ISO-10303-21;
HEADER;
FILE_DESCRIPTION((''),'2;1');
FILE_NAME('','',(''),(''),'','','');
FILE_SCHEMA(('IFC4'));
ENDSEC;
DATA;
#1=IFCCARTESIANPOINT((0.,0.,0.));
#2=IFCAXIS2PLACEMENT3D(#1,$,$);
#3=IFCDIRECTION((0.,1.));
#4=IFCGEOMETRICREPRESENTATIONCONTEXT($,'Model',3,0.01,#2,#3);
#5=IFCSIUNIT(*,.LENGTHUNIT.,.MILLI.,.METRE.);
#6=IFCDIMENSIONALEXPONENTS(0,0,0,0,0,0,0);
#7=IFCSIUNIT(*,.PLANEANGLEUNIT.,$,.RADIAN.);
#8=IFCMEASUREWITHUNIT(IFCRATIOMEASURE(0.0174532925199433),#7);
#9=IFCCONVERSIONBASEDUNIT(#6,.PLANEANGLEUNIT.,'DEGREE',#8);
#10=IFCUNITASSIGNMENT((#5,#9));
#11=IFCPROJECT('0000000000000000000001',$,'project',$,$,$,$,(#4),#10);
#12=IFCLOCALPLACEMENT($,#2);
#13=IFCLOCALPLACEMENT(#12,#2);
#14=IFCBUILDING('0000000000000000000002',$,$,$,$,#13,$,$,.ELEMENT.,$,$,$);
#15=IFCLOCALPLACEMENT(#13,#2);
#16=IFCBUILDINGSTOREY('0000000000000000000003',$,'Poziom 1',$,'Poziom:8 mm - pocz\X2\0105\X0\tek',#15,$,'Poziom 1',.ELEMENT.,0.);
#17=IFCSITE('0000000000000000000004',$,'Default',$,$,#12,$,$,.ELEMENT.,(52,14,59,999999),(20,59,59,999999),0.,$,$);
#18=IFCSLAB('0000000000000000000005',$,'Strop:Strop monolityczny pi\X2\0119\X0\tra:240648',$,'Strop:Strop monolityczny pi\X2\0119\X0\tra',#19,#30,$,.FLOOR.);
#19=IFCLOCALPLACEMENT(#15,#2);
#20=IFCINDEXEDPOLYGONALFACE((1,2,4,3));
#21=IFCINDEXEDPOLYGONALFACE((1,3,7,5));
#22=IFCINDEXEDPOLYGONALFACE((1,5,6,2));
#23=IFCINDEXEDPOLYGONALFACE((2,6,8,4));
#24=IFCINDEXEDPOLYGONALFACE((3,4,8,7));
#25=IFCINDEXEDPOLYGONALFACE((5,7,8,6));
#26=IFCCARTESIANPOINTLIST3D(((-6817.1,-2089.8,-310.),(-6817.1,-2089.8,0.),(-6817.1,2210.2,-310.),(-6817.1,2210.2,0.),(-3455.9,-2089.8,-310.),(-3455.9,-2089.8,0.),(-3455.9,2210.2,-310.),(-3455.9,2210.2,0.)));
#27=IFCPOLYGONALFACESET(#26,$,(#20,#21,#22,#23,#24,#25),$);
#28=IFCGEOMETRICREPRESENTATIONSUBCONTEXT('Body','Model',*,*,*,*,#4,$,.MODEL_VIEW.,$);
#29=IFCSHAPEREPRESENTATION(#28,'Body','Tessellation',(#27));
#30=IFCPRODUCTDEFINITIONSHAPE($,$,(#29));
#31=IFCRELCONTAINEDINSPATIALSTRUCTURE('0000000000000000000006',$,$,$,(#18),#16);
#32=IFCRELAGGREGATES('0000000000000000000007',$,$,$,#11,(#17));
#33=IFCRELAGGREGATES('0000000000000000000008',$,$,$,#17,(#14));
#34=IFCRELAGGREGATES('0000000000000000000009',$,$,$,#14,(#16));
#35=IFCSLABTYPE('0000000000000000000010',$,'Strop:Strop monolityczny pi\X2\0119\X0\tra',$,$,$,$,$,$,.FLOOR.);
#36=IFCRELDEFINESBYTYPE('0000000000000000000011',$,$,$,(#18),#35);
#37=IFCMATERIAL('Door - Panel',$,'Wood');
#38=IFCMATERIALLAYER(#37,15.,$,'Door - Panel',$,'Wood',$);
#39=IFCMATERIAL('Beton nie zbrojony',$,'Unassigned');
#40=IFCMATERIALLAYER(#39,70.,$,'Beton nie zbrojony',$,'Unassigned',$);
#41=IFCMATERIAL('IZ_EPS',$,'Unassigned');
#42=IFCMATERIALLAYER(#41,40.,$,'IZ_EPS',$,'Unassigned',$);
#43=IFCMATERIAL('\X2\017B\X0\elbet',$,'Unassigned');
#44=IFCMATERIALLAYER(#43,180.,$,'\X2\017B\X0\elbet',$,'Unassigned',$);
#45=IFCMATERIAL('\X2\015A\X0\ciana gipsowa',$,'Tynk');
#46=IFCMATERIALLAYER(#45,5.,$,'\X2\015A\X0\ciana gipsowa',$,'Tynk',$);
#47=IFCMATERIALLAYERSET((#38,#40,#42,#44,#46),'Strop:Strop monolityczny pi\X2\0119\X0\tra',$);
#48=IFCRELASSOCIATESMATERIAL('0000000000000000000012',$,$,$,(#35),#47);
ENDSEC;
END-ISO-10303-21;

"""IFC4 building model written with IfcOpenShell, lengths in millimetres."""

from ifc_helpers import new_model, entity, si_unit, converted_unit, direction, frame, origin, place, context, subcontext, project, spatial, indexed_curve, outline, extrude, material, layer, layer_set, type_object, element, save


model = new_model("IFC4")

# Units and contexts
model_context = context("Model", 3, precision=0.01, world=origin(), true_north=direction((0.0, 1.0)))
body_context = subcontext(model_context, "Body", "Model", "MODEL_VIEW")
ifc_project = project(units=[si_unit("LENGTHUNIT", "METRE", prefix="MILLI"), converted_unit("PLANEANGLEUNIT", "DEGREE", entity("IfcRatioMeasure", 0.0174532925199433), si_unit("PLANEANGLEUNIT", "RADIAN"), dimensions=[0, 0, 0, 0, 0, 0, 0])], contexts=[model_context])

# Site, building, storey
site_placement = place(None, origin())
site = spatial("IfcSite", under=ifc_project, at=site_placement, Name="Default", CompositionType="ELEMENT", RefLatitude=(52, 14, 59, 999999), RefLongitude=(20, 59, 59, 999999), RefElevation=0.0)
building_placement = place(site_placement, origin())
building = spatial("IfcBuilding", under=site, at=building_placement, CompositionType="ELEMENT")
storey_placement = place(building_placement, origin())
storey = spatial("IfcBuildingStorey", under=building, at=storey_placement, Name="Poziom 1", ObjectType="Poziom:8 mm - początek", LongName="Poziom 1", CompositionType="ELEMENT", Elevation=0.0)

# Slab
ifc_material_1 = material(Name="Door - Panel", Category="Wood")
ifc_layer_1 = layer(ifc_material_1, 15.0, Name="Door - Panel", Category="Wood")
ifc_material_2 = material(Name="Beton nie zbrojony", Category="Unassigned")
ifc_layer_2 = layer(ifc_material_2, 70.0, Name="Beton nie zbrojony", Category="Unassigned")
ifc_material_3 = material(Name="IZ_EPS", Category="Unassigned")
ifc_layer_3 = layer(ifc_material_3, 40.0, Name="IZ_EPS", Category="Unassigned")
ifc_material_4 = material(Name="Żelbet", Category="Unassigned")
ifc_layer_4 = layer(ifc_material_4, 180.0, Name="Żelbet", Category="Unassigned")
ifc_material_5 = material(Name="Ściana gipsowa", Category="Tynk")
ifc_layer_5 = layer(ifc_material_5, 5.0, Name="Ściana gipsowa", Category="Tynk")
ifc_layer_set = layer_set([ifc_layer_1, ifc_layer_2, ifc_layer_3, ifc_layer_4, ifc_layer_5], Name="Strop:Strop monolityczny piętra")
slab_type = type_object("IfcSlabType", Name="Strop:Strop monolityczny piętra", PredefinedType="FLOOR", material=ifc_layer_set)
slab_placement = place(storey_placement, origin())
element("IfcSlab", 1, at=slab_placement, inside=storey, type_object=slab_type, Name="Strop:Strop monolityczny piętra:240648", ObjectType="Strop:Strop monolityczny piętra", PredefinedType="FLOOR", context=body_context, shape_type="SweptSolid", body=[
    extrude(outline(indexed_curve([(-2150.0, -1680.6), (2150.0, -1680.6), (2150.0, 1680.6), (-2150.0, 1680.6), (-2150.0, -1680.6)], self_intersect=False)), frame((-5136.5, 60.2, 0.0), z_axis=(0.0, 0.0, -1.0), x_axis=(0.0, 1.0, 0.0)), (0.0, 0.0, 1.0), 310.0),
])

save(model, "model.ifc")
